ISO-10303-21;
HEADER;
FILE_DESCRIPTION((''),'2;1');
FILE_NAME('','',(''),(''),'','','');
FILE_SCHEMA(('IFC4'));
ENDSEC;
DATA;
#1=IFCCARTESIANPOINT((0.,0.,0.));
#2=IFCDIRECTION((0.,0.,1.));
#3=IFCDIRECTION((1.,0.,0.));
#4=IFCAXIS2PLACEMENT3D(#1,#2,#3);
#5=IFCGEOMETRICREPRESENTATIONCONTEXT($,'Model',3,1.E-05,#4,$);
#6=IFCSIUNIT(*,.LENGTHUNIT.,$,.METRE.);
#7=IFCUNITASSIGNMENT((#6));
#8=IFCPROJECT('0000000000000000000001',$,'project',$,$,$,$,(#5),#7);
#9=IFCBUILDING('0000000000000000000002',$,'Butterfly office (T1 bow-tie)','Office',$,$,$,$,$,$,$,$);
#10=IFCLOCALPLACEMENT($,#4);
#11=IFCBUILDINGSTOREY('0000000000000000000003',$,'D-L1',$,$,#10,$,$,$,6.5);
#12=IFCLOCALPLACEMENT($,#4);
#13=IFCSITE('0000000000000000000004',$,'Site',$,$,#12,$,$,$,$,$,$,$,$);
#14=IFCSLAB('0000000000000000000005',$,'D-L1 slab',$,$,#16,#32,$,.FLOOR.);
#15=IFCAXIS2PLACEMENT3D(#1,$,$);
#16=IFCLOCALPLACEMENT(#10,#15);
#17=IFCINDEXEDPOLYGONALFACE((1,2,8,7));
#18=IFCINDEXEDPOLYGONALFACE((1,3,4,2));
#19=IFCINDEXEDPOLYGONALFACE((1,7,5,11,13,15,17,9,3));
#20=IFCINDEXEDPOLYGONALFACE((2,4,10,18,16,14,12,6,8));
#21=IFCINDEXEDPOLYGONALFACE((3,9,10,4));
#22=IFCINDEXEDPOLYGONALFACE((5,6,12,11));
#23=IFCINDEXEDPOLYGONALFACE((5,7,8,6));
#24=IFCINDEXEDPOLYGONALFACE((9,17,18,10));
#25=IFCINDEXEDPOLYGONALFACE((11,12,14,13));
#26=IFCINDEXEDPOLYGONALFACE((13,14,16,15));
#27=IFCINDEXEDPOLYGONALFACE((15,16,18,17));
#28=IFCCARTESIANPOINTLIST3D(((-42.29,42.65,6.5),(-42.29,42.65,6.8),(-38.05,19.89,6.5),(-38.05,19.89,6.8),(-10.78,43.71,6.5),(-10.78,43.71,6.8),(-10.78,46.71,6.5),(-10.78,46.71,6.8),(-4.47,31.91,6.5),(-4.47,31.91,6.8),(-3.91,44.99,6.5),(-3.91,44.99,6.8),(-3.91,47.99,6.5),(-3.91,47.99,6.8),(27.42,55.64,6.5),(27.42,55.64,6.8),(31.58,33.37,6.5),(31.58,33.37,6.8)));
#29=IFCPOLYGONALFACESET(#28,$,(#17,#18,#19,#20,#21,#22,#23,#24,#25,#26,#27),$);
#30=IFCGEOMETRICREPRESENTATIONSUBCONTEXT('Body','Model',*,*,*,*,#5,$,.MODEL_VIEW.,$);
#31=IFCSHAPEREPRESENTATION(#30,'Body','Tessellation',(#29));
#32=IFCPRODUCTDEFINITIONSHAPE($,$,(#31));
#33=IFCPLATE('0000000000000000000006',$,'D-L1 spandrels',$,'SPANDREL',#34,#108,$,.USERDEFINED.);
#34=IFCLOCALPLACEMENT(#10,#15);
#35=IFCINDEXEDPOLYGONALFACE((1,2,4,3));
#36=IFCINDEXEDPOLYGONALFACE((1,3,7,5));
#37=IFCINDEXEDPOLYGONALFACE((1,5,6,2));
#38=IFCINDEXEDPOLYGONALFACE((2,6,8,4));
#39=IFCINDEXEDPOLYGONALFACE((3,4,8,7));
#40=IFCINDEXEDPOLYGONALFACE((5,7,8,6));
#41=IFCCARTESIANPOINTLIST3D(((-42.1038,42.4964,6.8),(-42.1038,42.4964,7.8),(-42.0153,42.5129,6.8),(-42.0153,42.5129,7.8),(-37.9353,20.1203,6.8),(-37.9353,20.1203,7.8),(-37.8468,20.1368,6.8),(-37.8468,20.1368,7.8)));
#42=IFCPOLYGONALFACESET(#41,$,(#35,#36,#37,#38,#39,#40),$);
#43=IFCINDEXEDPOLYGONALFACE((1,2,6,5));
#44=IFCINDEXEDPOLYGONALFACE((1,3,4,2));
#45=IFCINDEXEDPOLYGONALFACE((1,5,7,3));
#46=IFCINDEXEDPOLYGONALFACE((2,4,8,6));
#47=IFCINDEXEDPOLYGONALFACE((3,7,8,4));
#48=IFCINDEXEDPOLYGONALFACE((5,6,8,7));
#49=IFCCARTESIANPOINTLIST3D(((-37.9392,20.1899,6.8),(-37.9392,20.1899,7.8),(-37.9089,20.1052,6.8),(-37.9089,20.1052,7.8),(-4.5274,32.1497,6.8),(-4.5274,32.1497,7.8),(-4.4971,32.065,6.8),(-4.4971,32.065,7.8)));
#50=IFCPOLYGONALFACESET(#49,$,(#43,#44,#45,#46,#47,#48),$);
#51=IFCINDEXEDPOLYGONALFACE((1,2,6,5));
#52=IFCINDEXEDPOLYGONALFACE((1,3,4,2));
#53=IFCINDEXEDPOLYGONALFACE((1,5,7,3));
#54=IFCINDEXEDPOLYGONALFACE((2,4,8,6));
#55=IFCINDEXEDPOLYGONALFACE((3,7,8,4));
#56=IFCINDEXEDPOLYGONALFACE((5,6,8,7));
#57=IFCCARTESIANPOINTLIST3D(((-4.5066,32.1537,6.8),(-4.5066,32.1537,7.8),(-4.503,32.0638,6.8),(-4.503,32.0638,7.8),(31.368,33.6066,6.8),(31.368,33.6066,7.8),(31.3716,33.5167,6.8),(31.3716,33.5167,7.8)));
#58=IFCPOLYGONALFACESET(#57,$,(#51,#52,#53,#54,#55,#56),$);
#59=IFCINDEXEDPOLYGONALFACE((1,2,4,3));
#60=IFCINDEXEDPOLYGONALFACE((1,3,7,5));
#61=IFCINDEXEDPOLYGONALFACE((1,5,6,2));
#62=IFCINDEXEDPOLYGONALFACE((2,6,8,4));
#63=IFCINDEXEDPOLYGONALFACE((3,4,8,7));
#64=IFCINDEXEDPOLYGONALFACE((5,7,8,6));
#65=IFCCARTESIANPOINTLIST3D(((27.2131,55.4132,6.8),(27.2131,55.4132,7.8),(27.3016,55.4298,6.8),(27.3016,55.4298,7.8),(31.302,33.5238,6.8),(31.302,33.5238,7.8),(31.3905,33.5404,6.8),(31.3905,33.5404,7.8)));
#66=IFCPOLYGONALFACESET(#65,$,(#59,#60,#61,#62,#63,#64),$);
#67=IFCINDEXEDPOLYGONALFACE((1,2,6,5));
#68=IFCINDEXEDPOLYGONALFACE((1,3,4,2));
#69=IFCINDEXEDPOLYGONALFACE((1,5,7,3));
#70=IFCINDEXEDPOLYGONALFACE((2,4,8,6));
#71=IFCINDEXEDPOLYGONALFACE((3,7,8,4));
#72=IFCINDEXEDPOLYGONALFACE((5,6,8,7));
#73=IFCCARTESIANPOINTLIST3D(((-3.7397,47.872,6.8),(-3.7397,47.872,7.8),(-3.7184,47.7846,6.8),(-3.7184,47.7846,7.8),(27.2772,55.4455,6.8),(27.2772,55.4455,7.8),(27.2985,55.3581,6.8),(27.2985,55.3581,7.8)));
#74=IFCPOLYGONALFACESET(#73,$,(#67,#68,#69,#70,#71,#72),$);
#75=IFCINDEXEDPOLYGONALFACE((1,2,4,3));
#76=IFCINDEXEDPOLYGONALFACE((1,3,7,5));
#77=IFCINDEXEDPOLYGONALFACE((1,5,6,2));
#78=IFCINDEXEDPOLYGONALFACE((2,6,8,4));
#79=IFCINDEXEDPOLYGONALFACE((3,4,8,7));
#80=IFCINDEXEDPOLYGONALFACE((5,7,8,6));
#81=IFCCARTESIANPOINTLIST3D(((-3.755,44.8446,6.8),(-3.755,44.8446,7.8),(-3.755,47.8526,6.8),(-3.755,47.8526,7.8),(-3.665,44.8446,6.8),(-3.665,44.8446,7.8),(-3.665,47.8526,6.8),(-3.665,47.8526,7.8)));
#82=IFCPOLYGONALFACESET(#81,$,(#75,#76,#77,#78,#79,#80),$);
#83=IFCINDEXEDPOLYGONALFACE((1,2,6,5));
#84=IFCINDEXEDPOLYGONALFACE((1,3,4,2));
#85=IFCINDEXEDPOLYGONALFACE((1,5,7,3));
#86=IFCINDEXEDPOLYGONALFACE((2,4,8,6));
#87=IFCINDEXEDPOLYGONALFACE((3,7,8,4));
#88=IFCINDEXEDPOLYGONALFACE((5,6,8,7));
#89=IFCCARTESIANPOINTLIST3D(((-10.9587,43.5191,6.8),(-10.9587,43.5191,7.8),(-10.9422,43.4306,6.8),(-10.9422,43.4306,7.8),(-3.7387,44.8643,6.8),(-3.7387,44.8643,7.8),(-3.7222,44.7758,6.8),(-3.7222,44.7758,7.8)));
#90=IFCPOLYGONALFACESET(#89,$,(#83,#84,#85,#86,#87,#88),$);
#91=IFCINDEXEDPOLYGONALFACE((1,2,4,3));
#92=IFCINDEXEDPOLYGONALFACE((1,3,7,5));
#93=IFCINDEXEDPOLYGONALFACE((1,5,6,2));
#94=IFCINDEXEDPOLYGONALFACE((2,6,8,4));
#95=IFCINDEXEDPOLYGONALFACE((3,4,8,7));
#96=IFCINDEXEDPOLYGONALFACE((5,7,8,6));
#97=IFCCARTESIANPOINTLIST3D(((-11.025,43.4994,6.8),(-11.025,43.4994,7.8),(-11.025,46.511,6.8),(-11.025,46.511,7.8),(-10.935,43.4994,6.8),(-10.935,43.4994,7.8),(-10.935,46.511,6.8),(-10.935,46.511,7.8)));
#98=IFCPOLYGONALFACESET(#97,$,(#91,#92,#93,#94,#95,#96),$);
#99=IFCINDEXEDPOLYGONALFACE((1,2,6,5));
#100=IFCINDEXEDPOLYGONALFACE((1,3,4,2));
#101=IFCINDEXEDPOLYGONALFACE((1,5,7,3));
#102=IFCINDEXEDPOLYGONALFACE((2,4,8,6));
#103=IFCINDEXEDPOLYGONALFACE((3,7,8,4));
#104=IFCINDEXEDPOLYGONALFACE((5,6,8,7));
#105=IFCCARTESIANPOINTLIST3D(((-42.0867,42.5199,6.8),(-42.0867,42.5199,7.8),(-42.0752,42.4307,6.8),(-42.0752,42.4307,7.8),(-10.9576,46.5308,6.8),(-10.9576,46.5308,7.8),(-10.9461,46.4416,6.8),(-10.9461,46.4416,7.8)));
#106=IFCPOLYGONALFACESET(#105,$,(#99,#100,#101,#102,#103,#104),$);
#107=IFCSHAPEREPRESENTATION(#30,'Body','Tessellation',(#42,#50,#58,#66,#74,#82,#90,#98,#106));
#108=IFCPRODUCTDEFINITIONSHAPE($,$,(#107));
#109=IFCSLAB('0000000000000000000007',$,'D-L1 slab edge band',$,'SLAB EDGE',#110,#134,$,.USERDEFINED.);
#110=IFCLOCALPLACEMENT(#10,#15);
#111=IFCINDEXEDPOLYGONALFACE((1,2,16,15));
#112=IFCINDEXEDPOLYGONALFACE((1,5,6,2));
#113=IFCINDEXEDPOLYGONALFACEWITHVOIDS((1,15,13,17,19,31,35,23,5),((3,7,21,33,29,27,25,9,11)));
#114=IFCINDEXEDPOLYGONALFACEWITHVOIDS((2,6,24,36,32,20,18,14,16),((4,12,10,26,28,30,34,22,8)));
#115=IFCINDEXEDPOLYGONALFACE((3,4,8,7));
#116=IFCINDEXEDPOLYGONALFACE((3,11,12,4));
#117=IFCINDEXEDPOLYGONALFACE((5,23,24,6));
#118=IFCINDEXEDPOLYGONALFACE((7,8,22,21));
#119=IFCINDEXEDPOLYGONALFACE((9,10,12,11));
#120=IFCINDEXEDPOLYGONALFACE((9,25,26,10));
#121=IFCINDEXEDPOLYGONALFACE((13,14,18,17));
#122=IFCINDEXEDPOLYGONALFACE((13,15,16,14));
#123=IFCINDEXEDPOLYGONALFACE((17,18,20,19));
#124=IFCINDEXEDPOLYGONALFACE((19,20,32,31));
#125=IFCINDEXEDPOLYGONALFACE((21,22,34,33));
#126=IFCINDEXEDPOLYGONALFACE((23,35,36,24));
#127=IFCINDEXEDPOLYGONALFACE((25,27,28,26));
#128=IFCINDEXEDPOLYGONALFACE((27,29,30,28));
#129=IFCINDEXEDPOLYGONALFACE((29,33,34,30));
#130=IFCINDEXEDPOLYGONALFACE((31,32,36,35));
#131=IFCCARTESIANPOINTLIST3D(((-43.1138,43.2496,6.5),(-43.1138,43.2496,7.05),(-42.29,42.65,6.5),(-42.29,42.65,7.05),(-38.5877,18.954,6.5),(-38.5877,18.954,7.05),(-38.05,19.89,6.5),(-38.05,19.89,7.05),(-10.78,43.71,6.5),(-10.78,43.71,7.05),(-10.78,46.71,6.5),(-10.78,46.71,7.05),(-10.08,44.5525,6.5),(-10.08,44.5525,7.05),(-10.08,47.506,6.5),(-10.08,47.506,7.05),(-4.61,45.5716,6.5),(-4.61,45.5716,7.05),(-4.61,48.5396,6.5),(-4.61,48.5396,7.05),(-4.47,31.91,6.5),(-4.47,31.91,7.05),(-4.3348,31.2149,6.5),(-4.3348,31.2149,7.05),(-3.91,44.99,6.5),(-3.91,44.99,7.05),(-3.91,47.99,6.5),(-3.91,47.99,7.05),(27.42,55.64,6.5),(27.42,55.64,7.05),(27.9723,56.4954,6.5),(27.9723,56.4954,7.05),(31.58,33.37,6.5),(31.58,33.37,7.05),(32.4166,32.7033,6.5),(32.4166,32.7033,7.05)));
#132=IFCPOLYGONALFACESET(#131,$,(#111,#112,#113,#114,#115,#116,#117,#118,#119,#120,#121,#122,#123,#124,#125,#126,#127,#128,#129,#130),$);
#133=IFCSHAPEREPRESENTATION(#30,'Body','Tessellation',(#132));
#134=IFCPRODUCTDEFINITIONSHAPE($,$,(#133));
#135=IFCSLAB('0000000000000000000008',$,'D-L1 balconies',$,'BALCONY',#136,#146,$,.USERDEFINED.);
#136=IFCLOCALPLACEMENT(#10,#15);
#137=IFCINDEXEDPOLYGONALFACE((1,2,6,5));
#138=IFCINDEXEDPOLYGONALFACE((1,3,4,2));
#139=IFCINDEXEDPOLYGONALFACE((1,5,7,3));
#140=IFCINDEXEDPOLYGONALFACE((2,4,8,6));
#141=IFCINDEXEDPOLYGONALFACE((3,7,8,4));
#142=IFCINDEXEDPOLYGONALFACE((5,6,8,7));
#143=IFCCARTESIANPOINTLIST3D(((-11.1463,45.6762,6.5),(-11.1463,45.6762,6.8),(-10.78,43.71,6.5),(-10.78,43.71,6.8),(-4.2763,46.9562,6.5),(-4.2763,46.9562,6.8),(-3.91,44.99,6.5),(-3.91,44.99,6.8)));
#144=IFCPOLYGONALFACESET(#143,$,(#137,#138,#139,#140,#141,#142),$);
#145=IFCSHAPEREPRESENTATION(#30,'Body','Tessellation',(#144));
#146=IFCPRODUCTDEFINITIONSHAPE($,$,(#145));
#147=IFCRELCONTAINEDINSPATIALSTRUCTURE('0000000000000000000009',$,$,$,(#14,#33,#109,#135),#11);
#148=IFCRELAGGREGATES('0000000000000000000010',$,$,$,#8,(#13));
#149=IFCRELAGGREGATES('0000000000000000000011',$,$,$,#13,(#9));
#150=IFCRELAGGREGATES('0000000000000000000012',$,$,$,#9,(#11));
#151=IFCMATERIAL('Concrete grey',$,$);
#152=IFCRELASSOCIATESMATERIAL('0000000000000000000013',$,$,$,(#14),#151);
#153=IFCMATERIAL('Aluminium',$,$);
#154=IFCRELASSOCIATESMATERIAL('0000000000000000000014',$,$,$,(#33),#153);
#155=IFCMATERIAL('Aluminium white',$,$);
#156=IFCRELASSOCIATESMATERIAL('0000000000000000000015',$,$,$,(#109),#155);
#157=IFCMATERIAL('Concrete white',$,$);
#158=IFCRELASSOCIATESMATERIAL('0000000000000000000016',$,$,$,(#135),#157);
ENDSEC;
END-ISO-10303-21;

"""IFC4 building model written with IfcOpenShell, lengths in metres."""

from ifc_helpers import new_model, si_unit, frame, origin_with_axes, place, context, subcontext, project, spatial, polyline, outline, extrude, material, element, save


model = new_model("IFC4")

# Units and contexts
model_context = context("Model", 3, precision=1e-05, world=origin_with_axes())
body_context = subcontext(model_context, "Body", "Model", "MODEL_VIEW")
ifc_project = project(units=[si_unit("LENGTHUNIT", "METRE")], contexts=[model_context])

# Site, building, storey
site_placement = place(None, origin_with_axes())
site = spatial("IfcSite", under=ifc_project, at=site_placement, Name="Site")
building = spatial("IfcBuilding", under=site, Name="Butterfly office (T1 bow-tie)", Description="Office")
storey_placement = place(None, origin_with_axes())
storey = spatial("IfcBuildingStorey", under=building, at=storey_placement, Name="D-L1", Elevation=6.5)

# Shared definitions
ifc_material_1 = material(Name="Aluminium")

# Slab
ifc_material_2 = material(Name="Concrete grey")
slab_1_placement = place(storey_placement, origin_with_axes())
element("IfcSlab", 1, at=slab_1_placement, inside=storey, material=ifc_material_2, Name="D-L1 slab", PredefinedType="FLOOR", context=body_context, shape_type="SweptSolid", body=[
    extrude(outline(polyline([(-42.29, 42.65), (-38.05, 19.89), (-4.47, 31.91), (31.58, 33.37), (27.42, 55.64), (-3.91, 47.99), (-3.91, 44.99), (-10.78, 43.71), (-10.78, 46.71), (-42.29, 42.65)])), frame((0.0, 0.0, 6.5), z_axis=(0.0, 0.0, 1.0), x_axis=(1.0, 0.0, 0.0)), (0.0, 0.0, 1.0), 0.3),
])

# Plate
plate_placement = place(storey_placement, origin_with_axes())
element("IfcPlate", 2, at=plate_placement, inside=storey, material=ifc_material_1, Name="D-L1 spandrels", ObjectType="SPANDREL", PredefinedType="USERDEFINED", context=body_context, shape_type="SweptSolid", body=[
    extrude(outline(polyline([(-42.1038, 42.4964), (-37.9353, 20.1203), (-37.8468, 20.1368), (-42.0153, 42.5129), (-42.1038, 42.4964)])), frame((0.0, 0.0, 6.8), z_axis=(0.0, 0.0, 1.0), x_axis=(1.0, 0.0, 0.0)), (0.0, 0.0, 1.0), 1.0),
    extrude(outline(polyline([(-37.9089, 20.1052), (-4.4971, 32.065), (-4.5274, 32.1497), (-37.9392, 20.1899), (-37.9089, 20.1052)])), frame((0.0, 0.0, 6.8), z_axis=(0.0, 0.0, 1.0), x_axis=(1.0, 0.0, 0.0)), (0.0, 0.0, 1.0), 1.0),
    extrude(outline(polyline([(-4.503, 32.0638), (31.3716, 33.5167), (31.368, 33.6066), (-4.5066, 32.1537), (-4.503, 32.0638)])), frame((0.0, 0.0, 6.8), z_axis=(0.0, 0.0, 1.0), x_axis=(1.0, 0.0, 0.0)), (0.0, 0.0, 1.0), 1.0),
    extrude(outline(polyline([(31.3905, 33.5404), (27.3016, 55.4298), (27.2131, 55.4132), (31.302, 33.5238), (31.3905, 33.5404)])), frame((0.0, 0.0, 6.8), z_axis=(0.0, 0.0, 1.0), x_axis=(1.0, 0.0, 0.0)), (0.0, 0.0, 1.0), 1.0),
    extrude(outline(polyline([(27.2772, 55.4455), (-3.7397, 47.872), (-3.7184, 47.7846), (27.2985, 55.3581), (27.2772, 55.4455)])), frame((0.0, 0.0, 6.8), z_axis=(0.0, 0.0, 1.0), x_axis=(1.0, 0.0, 0.0)), (0.0, 0.0, 1.0), 1.0),
    extrude(outline(polyline([(-3.755, 47.8526), (-3.755, 44.8446), (-3.665, 44.8446), (-3.665, 47.8526), (-3.755, 47.8526)])), frame((0.0, 0.0, 6.8), z_axis=(0.0, 0.0, 1.0), x_axis=(1.0, 0.0, 0.0)), (0.0, 0.0, 1.0), 1.0),
    extrude(outline(polyline([(-3.7387, 44.8643), (-10.9587, 43.5191), (-10.9422, 43.4306), (-3.7222, 44.7758), (-3.7387, 44.8643)])), frame((0.0, 0.0, 6.8), z_axis=(0.0, 0.0, 1.0), x_axis=(1.0, 0.0, 0.0)), (0.0, 0.0, 1.0), 1.0),
    extrude(outline(polyline([(-10.935, 43.4994), (-10.935, 46.511), (-11.025, 46.511), (-11.025, 43.4994), (-10.935, 43.4994)])), frame((0.0, 0.0, 6.8), z_axis=(0.0, 0.0, 1.0), x_axis=(1.0, 0.0, 0.0)), (0.0, 0.0, 1.0), 1.0),
    extrude(outline(polyline([(-10.9576, 46.5308), (-42.0867, 42.5199), (-42.0752, 42.4307), (-10.9461, 46.4416), (-10.9576, 46.5308)])), frame((0.0, 0.0, 6.8), z_axis=(0.0, 0.0, 1.0), x_axis=(1.0, 0.0, 0.0)), (0.0, 0.0, 1.0), 1.0),
])

# Slabs
ifc_material_3 = material(Name="Aluminium white")
slab_2_placement = place(storey_placement, origin_with_axes())
element("IfcSlab", 3, at=slab_2_placement, inside=storey, material=ifc_material_3, Name="D-L1 slab edge band", ObjectType="SLAB EDGE", PredefinedType="USERDEFINED", context=body_context, shape_type="SweptSolid", body=[
    extrude(outline(polyline([(-43.1138, 43.2496), (-38.5877, 18.954), (-4.3348, 31.2149), (32.4166, 32.7033), (27.9723, 56.4954), (-4.61, 48.5396), (-4.61, 45.5716), (-10.08, 44.5525), (-10.08, 47.506), (-43.1138, 43.2496)]), holes=[polyline([(-42.29, 42.65), (-38.05, 19.89), (-4.47, 31.91), (31.58, 33.37), (27.42, 55.64), (-3.91, 47.99), (-3.91, 44.99), (-10.78, 43.71), (-10.78, 46.71), (-42.29, 42.65)])]), frame((0.0, 0.0, 6.5), z_axis=(0.0, 0.0, 1.0), x_axis=(1.0, 0.0, 0.0)), (0.0, 0.0, 1.0), 0.55),
])
ifc_material_4 = material(Name="Concrete white")
slab_3_placement = place(storey_placement, origin_with_axes())
element("IfcSlab", 4, at=slab_3_placement, inside=storey, material=ifc_material_4, Name="D-L1 balconies", ObjectType="BALCONY", PredefinedType="USERDEFINED", context=body_context, shape_type="SweptSolid", body=[
    extrude(outline(polyline([(-3.91, 44.99), (-10.78, 43.71), (-11.1463, 45.6762), (-4.2763, 46.9562), (-3.91, 44.99)])), frame((0.0, 0.0, 6.5), z_axis=(0.0, 0.0, 1.0), x_axis=(1.0, 0.0, 0.0)), (0.0, 0.0, 1.0), 0.3),
])

save(model, "model.ifc")
